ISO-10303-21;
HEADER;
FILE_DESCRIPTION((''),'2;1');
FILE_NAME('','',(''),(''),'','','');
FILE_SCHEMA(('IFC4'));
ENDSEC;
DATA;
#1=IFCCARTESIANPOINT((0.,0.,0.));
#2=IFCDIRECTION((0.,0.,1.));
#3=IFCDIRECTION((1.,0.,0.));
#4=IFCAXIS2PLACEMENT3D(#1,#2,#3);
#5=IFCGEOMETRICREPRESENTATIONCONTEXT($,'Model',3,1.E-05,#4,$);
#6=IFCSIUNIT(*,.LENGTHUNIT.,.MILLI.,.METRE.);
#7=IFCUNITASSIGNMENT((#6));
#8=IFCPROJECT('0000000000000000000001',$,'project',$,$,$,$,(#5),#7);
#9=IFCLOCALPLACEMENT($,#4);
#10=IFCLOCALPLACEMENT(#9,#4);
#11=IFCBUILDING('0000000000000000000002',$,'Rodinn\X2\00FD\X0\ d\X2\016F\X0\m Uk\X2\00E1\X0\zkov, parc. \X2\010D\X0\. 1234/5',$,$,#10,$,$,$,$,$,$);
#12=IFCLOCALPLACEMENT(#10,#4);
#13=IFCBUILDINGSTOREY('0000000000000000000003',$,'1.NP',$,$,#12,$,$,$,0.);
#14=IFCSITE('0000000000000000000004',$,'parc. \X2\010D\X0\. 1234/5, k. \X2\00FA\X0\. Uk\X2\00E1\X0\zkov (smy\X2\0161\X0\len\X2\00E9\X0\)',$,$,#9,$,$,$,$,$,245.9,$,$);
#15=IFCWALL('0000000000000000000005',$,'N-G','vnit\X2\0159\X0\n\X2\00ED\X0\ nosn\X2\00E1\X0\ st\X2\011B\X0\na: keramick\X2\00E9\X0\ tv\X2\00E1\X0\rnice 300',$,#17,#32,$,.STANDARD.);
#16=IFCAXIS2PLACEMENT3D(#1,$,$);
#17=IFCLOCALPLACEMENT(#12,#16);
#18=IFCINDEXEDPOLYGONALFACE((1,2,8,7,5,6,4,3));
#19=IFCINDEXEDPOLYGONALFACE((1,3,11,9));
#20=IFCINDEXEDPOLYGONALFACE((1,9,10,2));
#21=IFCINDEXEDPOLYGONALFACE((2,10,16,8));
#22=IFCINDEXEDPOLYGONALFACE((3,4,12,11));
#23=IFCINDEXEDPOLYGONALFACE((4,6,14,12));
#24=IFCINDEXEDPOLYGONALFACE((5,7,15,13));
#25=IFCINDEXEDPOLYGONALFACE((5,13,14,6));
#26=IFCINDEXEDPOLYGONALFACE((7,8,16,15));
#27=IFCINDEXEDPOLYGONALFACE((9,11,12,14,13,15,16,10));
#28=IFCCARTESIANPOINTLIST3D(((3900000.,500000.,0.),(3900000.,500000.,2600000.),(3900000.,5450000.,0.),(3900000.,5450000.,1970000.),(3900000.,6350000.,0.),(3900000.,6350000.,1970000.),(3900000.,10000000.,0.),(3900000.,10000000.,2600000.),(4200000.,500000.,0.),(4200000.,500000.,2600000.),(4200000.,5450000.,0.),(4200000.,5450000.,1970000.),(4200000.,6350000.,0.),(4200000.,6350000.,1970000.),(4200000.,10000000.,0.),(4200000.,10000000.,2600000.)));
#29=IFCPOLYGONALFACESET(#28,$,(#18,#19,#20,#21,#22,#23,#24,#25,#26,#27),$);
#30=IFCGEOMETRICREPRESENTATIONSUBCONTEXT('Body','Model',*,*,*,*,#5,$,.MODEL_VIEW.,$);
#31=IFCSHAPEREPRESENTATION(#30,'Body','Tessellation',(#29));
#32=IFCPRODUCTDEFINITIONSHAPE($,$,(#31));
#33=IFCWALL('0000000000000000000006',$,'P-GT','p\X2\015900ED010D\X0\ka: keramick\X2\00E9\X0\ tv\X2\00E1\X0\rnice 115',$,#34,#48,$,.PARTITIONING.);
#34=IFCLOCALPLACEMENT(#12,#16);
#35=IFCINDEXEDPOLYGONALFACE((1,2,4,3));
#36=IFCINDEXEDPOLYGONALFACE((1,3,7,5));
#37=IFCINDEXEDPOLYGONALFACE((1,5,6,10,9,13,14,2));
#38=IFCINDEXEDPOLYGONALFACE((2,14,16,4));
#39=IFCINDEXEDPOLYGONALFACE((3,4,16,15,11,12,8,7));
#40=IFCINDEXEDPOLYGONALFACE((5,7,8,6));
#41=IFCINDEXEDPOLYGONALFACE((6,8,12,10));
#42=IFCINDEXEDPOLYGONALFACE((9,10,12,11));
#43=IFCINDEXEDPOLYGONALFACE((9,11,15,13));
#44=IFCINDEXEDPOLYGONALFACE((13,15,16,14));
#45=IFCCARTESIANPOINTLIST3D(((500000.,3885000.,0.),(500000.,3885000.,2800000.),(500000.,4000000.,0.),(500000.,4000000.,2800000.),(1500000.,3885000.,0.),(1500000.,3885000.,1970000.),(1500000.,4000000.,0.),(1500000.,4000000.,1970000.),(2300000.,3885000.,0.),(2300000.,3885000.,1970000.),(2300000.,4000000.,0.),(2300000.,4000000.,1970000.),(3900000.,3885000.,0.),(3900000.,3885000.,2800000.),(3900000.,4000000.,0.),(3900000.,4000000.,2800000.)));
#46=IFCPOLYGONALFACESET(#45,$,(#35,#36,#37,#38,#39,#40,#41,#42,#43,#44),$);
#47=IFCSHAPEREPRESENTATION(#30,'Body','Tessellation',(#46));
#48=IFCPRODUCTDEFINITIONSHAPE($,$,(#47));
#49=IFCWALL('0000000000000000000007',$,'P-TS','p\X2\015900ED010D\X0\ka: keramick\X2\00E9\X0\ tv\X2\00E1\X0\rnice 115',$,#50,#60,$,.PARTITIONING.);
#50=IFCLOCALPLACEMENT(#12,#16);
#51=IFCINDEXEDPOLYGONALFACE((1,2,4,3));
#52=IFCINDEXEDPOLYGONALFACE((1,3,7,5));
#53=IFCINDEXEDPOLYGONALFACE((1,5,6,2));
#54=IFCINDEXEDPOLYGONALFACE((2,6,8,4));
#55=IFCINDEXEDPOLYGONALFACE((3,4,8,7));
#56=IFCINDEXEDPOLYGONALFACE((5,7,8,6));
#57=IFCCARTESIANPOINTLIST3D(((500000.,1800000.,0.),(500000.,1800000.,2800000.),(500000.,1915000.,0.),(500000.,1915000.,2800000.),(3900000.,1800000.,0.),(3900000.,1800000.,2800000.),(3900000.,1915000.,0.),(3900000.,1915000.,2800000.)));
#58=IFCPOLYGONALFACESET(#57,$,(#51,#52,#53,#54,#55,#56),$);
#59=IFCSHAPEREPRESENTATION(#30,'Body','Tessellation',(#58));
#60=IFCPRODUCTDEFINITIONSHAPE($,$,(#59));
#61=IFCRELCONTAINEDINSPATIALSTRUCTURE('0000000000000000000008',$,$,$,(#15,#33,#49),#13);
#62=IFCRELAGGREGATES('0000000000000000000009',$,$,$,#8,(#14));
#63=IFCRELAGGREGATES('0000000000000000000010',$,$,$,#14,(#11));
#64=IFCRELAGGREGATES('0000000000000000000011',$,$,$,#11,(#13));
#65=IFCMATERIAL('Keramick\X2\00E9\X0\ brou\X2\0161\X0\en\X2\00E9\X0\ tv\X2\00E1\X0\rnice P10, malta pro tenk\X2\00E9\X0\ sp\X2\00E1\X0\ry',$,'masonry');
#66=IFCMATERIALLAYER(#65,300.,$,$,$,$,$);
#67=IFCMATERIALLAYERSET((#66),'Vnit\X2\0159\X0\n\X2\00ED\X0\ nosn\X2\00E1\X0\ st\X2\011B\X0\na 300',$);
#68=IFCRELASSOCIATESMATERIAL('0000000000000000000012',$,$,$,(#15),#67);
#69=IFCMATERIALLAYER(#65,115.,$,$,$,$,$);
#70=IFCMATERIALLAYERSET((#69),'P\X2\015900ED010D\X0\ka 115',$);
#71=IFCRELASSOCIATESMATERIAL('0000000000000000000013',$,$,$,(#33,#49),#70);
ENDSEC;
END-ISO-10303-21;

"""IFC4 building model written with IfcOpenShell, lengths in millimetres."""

from ifc_helpers import new_model, si_unit, frame, origin_with_axes, place, context, subcontext, project, spatial, indexed_curve, outline, extrude, material, layer, layer_set, element, save


model = new_model("IFC4")

# Units and contexts
model_context = context("Model", 3, precision=1e-05, world=origin_with_axes())
body_context = subcontext(model_context, "Body", "Model", "MODEL_VIEW")
ifc_project = project(units=[si_unit("LENGTHUNIT", "METRE", prefix="MILLI")], contexts=[model_context])

# Site, building, storey
site_placement = place(None, origin_with_axes())
site = spatial("IfcSite", under=ifc_project, at=site_placement, Name="parc. č. 1234/5, k. ú. Ukázkov (smyšlené)", RefElevation=245.9)
building_placement = place(site_placement, origin_with_axes())
building = spatial("IfcBuilding", under=site, at=building_placement, Name="Rodinný dům Ukázkov, parc. č. 1234/5")
storey_placement = place(building_placement, origin_with_axes())
storey = spatial("IfcBuildingStorey", under=building, at=storey_placement, Name="1.NP", Elevation=0.0)

# Shared definitions
ifc_material_1 = material(Name="Keramické broušené tvárnice P10, malta pro tenké spáry", Category="masonry")

# Wall, opening
ifc_layer_1 = layer(ifc_material_1, 300.0)
ifc_layer_set_1 = layer_set([ifc_layer_1], Name="Vnitřní nosná stěna 300")
wall_1_placement = place(storey_placement, frame((4200000.0, 500000.0, 0.0), z_axis=(0.0, 0.0, 1.0), x_axis=(0.0, 1.0, 0.0)))
wall_1 = element("IfcWall", 1, at=wall_1_placement, inside=storey, material=ifc_layer_set_1, Name="N-G", Description="vnitřní nosná stěna: keramické tvárnice 300", PredefinedType="STANDARD", context=body_context, shape_type="SweptSolid", body=[
    extrude(outline(indexed_curve([(0.0, 0.0), (0.0, 300000.0), (9500000.0, 300000.0), (9500000.0, 0.0), (0.0, 0.0)], self_intersect=False)), origin_with_axes(), (0.0, 0.0, 1.0), 2600000.0),
])
opening_1_placement = place(wall_1_placement, frame((4950000.0, -20000.0, 0.0), z_axis=(0.0, 0.0, 1.0), x_axis=(1.0, 0.0, 0.0)))
element("IfcOpeningElement", 2, at=opening_1_placement, cuts=wall_1, context=body_context, shape_type="SweptSolid", body=[
    extrude(outline(indexed_curve([(0.0, 0.0), (0.0, 340000.0), (900000.0, 340000.0), (900000.0, 0.0), (0.0, 0.0)], self_intersect=False)), origin_with_axes(), (0.0, 0.0, 1.0), 1970000.0),
])

# Wall, opening
ifc_layer_2 = layer(ifc_material_1, 115.0)
ifc_layer_set_2 = layer_set([ifc_layer_2], Name="Příčka 115")
wall_2_placement = place(storey_placement, frame((500000.0, 3885000.0, 0.0), z_axis=(0.0, 0.0, 1.0), x_axis=(1.0, 0.0, 0.0)))
wall_2 = element("IfcWall", 3, at=wall_2_placement, inside=storey, material=ifc_layer_set_2, Name="P-GT", Description="příčka: keramické tvárnice 115", PredefinedType="PARTITIONING", context=body_context, shape_type="SweptSolid", body=[
    extrude(outline(indexed_curve([(0.0, 0.0), (0.0, 115000.0), (3400000.0, 115000.0), (3400000.0, 0.0), (0.0, 0.0)], self_intersect=False)), origin_with_axes(), (0.0, 0.0, 1.0), 2800000.0),
])
opening_2_placement = place(wall_2_placement, frame((1000000.0, -20000.0, 0.0), z_axis=(0.0, 0.0, 1.0), x_axis=(1.0, 0.0, 0.0)))
element("IfcOpeningElement", 4, at=opening_2_placement, cuts=wall_2, context=body_context, shape_type="SweptSolid", body=[
    extrude(outline(indexed_curve([(0.0, 0.0), (0.0, 155000.0), (800000.0, 155000.0), (800000.0, 0.0), (0.0, 0.0)], self_intersect=False)), origin_with_axes(), (0.0, 0.0, 1.0), 1970000.0),
])

# Wall
wall_3_placement = place(storey_placement, frame((500000.0, 1800000.0, 0.0), z_axis=(0.0, 0.0, 1.0), x_axis=(1.0, 0.0, 0.0)))
element("IfcWall", 5, at=wall_3_placement, inside=storey, material=ifc_layer_set_2, Name="P-TS", Description="příčka: keramické tvárnice 115", PredefinedType="PARTITIONING", context=body_context, shape_type="SweptSolid", body=[
    extrude(outline(indexed_curve([(0.0, 0.0), (0.0, 115000.0), (3400000.0, 115000.0), (3400000.0, 0.0), (0.0, 0.0)], self_intersect=False)), origin_with_axes(), (0.0, 0.0, 1.0), 2800000.0),
])

save(model, "model.ifc")
